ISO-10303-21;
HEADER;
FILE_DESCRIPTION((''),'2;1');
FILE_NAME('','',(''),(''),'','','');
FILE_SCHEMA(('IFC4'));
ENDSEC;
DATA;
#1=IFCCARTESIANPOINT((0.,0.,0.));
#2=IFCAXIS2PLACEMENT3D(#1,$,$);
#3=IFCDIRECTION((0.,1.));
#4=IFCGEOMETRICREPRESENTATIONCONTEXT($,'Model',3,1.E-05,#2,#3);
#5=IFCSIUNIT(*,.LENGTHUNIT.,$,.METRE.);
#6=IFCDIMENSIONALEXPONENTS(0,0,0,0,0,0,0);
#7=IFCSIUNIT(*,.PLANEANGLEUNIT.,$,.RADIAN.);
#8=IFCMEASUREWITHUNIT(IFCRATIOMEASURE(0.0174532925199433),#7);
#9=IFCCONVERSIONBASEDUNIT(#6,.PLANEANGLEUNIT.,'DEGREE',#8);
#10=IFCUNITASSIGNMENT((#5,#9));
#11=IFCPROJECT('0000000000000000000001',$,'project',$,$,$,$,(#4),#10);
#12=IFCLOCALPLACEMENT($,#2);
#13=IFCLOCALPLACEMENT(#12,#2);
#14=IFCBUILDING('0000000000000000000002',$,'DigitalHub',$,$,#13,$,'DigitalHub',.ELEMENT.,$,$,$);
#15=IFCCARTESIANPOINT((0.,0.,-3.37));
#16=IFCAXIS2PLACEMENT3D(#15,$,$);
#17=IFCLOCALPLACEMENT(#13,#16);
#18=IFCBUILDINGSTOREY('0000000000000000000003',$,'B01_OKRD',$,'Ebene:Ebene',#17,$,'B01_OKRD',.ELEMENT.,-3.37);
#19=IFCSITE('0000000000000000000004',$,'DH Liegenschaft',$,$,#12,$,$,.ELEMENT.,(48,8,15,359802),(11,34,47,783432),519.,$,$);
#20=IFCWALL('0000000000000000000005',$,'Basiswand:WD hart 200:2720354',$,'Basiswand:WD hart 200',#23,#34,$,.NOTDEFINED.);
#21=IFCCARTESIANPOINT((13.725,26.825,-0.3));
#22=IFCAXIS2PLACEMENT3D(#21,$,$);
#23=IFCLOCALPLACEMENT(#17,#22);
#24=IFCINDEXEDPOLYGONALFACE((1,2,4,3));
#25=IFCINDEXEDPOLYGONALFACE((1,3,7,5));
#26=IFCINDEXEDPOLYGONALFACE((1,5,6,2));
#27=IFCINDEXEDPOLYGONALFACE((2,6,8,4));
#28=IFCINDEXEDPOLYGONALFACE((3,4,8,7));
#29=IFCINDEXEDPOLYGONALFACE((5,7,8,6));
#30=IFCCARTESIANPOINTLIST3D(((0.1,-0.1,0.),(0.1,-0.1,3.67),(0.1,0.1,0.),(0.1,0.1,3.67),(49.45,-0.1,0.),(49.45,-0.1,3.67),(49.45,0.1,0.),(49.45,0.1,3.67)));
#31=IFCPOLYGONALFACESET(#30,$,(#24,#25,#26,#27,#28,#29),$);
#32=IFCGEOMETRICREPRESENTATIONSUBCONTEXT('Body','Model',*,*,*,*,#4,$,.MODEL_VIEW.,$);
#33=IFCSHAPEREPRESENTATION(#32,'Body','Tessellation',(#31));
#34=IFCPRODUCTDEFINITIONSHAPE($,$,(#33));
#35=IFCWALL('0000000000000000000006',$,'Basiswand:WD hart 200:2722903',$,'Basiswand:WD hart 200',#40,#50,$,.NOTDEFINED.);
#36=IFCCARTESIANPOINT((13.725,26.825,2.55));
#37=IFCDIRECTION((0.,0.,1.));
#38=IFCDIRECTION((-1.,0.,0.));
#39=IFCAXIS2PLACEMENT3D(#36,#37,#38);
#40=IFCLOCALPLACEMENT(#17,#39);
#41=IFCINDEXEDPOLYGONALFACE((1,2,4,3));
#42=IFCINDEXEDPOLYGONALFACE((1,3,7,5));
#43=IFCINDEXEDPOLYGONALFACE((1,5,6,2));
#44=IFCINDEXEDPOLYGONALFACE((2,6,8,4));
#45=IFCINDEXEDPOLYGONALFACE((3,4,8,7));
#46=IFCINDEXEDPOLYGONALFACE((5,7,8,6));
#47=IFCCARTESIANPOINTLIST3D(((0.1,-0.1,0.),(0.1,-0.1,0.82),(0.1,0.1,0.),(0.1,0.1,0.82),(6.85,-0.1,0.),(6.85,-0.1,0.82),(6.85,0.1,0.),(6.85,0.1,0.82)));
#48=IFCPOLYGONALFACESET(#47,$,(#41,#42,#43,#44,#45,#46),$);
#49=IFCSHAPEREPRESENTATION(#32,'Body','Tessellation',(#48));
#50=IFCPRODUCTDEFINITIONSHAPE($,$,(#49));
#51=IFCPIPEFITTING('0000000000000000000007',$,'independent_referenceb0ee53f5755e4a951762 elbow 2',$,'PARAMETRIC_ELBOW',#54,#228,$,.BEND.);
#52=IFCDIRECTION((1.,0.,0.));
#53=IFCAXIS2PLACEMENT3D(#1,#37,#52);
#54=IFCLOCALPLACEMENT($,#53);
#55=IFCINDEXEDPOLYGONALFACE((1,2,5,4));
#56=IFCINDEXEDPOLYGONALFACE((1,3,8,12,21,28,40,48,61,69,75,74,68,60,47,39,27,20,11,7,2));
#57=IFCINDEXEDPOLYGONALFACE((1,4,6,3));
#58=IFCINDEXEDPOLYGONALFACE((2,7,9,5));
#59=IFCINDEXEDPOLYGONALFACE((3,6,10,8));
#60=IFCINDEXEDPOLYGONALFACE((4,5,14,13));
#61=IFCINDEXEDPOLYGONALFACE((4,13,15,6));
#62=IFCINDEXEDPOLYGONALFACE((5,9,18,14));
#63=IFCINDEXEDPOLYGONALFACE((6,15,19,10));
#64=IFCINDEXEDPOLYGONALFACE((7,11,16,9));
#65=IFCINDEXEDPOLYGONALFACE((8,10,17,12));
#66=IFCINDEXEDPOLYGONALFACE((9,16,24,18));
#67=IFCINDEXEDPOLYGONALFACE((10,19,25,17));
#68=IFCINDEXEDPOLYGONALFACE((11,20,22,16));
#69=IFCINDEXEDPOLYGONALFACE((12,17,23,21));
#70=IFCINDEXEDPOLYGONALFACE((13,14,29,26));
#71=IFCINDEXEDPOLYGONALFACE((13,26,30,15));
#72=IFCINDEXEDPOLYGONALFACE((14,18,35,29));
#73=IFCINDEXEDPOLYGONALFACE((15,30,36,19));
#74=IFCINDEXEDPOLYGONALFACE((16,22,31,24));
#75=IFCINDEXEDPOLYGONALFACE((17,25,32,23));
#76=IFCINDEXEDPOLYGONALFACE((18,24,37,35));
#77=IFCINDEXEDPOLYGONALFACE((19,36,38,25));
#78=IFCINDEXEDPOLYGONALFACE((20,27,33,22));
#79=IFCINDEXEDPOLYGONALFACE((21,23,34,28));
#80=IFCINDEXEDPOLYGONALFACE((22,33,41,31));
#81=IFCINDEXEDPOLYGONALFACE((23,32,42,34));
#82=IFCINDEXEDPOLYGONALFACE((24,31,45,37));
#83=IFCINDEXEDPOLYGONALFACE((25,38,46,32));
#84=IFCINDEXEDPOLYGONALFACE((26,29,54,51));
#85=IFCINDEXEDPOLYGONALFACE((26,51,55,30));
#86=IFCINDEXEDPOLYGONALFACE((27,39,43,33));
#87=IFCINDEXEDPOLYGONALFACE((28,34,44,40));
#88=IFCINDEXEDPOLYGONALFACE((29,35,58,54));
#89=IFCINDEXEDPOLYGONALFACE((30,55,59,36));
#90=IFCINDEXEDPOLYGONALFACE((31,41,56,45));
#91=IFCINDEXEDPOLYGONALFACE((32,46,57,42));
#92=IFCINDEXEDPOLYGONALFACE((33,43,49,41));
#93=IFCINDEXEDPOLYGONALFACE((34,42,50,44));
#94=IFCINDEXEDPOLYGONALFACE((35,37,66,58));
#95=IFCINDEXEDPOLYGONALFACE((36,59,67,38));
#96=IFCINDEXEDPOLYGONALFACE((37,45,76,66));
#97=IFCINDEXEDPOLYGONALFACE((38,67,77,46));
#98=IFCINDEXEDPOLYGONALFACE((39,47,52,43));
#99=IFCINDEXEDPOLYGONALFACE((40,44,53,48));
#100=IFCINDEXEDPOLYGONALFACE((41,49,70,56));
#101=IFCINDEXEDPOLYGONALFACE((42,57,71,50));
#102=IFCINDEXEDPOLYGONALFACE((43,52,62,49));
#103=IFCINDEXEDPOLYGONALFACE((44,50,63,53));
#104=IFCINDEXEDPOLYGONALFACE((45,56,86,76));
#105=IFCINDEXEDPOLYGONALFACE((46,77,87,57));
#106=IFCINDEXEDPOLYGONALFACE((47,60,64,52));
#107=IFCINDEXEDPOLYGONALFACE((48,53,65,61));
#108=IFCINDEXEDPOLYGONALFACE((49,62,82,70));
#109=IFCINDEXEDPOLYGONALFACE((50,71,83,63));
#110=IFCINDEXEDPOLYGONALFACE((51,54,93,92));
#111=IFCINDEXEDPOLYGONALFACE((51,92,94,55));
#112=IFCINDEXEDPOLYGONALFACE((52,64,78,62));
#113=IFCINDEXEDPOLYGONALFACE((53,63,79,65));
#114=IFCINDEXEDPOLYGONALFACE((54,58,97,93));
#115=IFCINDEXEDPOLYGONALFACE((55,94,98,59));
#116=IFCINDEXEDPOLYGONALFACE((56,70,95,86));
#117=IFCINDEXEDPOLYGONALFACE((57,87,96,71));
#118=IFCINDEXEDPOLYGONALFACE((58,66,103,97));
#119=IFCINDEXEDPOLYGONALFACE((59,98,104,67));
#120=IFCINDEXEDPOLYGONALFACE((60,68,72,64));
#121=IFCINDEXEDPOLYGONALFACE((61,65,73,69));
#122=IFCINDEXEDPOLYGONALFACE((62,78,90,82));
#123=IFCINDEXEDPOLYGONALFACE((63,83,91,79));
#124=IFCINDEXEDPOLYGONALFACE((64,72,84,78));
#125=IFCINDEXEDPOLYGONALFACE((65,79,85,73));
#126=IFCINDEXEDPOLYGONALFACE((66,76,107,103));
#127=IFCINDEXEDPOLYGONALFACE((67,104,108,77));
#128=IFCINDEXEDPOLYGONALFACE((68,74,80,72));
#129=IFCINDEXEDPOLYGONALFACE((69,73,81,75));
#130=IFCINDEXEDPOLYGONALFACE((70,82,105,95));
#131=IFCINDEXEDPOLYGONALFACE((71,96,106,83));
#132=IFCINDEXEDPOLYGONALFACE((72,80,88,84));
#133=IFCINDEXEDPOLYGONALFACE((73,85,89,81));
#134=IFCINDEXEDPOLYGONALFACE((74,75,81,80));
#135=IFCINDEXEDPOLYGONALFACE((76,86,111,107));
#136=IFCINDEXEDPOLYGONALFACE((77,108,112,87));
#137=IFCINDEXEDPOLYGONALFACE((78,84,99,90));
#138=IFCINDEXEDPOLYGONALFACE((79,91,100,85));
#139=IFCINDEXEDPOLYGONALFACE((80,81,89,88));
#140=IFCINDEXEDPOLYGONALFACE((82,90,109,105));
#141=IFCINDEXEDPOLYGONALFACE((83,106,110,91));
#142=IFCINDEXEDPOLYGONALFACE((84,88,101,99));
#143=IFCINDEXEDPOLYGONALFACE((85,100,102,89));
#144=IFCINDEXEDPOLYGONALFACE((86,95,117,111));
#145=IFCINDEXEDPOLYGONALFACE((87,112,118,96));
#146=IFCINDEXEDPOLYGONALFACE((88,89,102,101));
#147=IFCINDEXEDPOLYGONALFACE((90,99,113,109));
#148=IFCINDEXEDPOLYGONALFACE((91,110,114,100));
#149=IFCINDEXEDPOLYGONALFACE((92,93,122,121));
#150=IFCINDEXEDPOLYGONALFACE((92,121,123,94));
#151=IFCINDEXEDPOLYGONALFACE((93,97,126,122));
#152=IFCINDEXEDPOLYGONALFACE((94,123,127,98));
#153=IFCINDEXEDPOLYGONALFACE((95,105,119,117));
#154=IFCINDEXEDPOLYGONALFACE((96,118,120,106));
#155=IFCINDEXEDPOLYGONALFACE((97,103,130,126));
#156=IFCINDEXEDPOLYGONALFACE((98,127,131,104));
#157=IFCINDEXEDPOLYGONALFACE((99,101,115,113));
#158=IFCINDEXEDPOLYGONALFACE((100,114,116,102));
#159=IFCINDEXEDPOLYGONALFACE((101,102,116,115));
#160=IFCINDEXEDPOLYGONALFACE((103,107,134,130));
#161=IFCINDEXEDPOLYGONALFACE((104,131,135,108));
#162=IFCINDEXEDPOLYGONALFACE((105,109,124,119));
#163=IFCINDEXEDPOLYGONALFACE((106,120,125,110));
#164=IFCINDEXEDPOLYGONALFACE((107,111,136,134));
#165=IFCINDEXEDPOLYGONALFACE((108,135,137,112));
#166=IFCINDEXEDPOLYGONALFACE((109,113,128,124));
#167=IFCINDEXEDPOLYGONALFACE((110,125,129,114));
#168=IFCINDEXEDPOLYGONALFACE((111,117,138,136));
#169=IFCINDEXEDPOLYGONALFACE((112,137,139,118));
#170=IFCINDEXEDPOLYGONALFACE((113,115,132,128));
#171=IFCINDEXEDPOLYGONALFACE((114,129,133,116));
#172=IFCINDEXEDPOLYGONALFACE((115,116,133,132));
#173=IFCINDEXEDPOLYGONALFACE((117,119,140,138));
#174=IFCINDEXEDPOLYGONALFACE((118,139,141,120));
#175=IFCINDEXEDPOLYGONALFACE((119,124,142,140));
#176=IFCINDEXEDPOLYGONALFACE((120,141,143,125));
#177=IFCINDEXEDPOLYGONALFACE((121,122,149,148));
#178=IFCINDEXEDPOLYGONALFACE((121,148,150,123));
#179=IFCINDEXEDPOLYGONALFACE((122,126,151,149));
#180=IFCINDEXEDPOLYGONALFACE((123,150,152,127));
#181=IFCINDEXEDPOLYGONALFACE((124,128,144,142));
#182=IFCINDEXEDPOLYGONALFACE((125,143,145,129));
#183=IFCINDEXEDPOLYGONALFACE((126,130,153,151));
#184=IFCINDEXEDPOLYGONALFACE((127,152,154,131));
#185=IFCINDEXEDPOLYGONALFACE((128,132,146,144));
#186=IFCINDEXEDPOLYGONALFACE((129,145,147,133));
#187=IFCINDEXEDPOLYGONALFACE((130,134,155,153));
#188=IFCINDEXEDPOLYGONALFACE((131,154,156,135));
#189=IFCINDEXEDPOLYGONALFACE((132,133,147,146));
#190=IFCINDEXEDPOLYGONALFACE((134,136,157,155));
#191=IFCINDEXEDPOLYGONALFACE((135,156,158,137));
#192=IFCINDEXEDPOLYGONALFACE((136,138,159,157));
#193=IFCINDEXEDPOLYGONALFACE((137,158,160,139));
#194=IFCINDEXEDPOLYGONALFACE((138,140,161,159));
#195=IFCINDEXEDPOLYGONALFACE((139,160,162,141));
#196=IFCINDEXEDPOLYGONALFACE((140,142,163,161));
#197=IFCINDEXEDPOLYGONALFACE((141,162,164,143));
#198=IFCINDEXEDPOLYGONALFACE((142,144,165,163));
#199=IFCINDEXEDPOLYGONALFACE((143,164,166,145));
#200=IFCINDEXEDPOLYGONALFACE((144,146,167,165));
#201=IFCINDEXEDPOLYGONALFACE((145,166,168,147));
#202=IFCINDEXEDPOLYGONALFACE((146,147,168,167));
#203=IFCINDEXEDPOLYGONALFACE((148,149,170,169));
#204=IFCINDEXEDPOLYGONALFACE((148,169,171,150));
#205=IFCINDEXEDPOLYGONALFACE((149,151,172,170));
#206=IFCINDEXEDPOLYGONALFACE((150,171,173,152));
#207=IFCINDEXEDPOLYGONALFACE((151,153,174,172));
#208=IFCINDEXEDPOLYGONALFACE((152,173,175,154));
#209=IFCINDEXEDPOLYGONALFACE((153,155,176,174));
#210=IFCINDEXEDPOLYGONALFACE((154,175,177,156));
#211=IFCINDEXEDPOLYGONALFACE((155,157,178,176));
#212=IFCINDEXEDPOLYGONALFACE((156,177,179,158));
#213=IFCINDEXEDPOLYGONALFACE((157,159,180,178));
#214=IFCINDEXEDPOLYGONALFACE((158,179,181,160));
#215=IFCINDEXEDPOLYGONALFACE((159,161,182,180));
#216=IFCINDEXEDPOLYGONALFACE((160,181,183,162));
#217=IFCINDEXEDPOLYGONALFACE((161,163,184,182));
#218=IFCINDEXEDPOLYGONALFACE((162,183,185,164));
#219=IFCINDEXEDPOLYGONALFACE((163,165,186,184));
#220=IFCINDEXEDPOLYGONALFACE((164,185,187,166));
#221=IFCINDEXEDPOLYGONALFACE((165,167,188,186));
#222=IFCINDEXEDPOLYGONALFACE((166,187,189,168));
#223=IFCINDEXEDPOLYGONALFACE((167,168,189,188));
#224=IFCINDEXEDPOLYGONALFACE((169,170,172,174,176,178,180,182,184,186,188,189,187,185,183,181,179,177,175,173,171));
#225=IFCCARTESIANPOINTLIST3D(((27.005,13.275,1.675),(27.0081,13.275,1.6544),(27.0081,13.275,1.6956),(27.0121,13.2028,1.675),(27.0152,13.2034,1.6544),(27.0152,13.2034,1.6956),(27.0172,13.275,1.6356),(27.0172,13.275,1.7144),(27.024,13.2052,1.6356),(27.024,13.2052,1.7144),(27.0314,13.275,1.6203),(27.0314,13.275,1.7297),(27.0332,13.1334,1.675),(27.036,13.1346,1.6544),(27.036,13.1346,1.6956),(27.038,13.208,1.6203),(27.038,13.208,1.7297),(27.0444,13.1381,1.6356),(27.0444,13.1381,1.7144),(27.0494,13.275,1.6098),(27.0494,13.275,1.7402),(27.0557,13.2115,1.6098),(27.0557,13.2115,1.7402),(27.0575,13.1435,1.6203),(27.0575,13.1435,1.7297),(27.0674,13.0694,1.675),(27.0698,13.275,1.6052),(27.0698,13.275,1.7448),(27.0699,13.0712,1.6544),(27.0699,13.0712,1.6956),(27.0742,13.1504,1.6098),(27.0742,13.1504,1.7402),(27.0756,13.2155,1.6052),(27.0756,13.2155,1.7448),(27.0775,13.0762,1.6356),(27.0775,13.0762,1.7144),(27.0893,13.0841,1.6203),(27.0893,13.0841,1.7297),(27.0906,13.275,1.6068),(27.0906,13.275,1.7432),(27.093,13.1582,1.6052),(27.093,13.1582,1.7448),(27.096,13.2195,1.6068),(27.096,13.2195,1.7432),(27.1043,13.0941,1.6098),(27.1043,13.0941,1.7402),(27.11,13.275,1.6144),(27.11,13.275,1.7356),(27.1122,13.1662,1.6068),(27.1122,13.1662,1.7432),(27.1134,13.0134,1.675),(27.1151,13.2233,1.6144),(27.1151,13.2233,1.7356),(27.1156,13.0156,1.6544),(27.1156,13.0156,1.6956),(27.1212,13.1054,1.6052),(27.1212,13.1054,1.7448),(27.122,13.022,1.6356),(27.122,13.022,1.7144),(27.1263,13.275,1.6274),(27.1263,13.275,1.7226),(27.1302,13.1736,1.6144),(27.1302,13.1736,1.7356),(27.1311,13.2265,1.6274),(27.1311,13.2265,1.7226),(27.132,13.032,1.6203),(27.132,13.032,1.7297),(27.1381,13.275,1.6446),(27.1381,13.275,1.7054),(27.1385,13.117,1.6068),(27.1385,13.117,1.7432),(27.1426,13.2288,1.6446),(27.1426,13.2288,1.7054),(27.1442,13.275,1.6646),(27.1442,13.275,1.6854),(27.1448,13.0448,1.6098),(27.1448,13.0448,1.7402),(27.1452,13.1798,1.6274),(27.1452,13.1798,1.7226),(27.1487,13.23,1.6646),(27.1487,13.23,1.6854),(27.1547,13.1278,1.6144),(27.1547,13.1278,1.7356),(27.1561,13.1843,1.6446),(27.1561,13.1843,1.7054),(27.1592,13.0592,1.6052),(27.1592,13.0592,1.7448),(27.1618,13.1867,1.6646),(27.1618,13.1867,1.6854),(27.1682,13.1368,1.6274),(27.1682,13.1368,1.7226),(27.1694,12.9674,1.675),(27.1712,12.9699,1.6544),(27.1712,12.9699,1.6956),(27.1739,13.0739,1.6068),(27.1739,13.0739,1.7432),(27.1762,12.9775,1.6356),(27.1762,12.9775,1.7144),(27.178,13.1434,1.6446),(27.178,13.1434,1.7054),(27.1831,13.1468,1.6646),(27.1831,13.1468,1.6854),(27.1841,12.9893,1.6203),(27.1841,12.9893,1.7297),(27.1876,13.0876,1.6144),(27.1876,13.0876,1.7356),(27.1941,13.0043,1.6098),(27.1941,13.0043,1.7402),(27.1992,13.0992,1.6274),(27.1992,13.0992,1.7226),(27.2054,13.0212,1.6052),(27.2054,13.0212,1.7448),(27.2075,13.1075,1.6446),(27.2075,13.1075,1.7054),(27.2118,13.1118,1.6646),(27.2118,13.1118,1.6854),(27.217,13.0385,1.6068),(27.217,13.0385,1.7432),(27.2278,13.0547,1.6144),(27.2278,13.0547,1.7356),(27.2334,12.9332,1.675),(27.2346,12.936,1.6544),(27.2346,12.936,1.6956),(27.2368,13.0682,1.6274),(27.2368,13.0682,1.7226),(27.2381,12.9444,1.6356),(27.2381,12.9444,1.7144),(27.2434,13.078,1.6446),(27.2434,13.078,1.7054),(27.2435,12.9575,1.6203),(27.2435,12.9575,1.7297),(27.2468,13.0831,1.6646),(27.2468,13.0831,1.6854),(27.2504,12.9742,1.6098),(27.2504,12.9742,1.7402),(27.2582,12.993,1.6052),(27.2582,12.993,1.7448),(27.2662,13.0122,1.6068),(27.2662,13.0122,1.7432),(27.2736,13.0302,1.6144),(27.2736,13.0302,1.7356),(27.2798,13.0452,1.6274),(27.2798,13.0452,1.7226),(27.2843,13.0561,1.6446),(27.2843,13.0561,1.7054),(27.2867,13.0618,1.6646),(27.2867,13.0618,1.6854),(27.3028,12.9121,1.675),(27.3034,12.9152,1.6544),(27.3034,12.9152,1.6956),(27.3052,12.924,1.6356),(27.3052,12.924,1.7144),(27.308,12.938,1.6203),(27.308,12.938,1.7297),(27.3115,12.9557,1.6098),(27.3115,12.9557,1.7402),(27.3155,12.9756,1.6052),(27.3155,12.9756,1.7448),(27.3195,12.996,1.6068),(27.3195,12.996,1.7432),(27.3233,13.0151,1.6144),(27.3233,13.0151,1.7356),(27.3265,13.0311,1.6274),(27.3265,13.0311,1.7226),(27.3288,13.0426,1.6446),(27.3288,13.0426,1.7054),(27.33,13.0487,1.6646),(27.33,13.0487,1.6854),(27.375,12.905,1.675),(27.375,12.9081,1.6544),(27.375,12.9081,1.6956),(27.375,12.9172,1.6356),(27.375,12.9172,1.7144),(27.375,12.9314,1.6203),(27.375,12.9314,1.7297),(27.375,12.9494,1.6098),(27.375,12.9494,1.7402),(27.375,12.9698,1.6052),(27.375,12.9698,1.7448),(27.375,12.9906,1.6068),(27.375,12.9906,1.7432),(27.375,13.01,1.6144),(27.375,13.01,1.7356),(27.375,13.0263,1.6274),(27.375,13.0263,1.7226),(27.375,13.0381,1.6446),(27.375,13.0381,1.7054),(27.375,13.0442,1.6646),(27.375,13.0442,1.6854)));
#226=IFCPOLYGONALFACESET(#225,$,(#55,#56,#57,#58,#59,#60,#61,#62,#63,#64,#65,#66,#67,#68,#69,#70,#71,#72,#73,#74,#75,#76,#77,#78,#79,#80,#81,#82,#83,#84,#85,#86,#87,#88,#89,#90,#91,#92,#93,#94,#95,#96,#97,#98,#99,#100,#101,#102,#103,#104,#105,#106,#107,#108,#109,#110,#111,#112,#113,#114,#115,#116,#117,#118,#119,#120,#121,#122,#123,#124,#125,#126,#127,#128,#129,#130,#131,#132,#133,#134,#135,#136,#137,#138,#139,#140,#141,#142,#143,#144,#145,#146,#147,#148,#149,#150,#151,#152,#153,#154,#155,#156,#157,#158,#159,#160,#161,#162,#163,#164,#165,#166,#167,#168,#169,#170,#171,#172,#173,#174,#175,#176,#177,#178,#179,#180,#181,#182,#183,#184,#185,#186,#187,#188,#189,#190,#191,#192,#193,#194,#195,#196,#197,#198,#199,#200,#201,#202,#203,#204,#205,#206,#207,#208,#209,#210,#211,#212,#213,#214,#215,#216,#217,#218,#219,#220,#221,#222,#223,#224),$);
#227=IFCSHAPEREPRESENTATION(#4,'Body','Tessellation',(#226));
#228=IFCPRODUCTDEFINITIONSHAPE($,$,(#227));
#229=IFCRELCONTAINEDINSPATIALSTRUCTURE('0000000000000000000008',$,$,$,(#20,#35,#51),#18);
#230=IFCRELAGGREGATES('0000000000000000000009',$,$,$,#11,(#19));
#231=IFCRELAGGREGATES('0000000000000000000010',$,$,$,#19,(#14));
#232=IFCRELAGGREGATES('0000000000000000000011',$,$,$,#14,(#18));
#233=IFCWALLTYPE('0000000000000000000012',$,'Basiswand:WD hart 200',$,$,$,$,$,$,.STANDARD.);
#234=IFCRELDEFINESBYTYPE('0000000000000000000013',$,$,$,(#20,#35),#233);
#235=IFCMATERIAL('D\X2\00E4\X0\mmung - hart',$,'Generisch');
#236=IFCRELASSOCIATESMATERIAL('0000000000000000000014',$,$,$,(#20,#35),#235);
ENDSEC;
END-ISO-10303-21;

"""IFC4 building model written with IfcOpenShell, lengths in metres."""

from ifc_helpers import new_model, entity, si_unit, converted_unit, direction, frame, origin, origin_with_axes, place, context, subcontext, project, spatial, indexed_curve, outline, extrude, material, type_object, element, save


model = new_model("IFC4")

# Units and contexts
model_context = context("Model", 3, precision=1e-05, world=origin(), true_north=direction((0.0, 1.0)))
body_context = subcontext(model_context, "Body", "Model", "MODEL_VIEW")
ifc_project = project(units=[si_unit("LENGTHUNIT", "METRE"), converted_unit("PLANEANGLEUNIT", "DEGREE", entity("IfcRatioMeasure", 0.0174532925199433), si_unit("PLANEANGLEUNIT", "RADIAN"), dimensions=[0, 0, 0, 0, 0, 0, 0])], contexts=[model_context])

# Site, building, storey
site_placement = place(None, frame((0.0, 0.0, 0.0)))
site = spatial("IfcSite", under=ifc_project, at=site_placement, Name="DH Liegenschaft", CompositionType="ELEMENT", RefLatitude=(48, 8, 15, 359802), RefLongitude=(11, 34, 47, 783432), RefElevation=519.0)
building_placement = place(site_placement, origin())
building = spatial("IfcBuilding", under=site, at=building_placement, Name="DigitalHub", LongName="DigitalHub", CompositionType="ELEMENT")
storey_placement = place(building_placement, frame((0.0, 0.0, -3.37)))
storey = spatial("IfcBuildingStorey", under=building, at=storey_placement, Name="B01_OKRD", ObjectType="Ebene:Ebene", LongName="B01_OKRD", CompositionType="ELEMENT", Elevation=-3.37)

# Shared definitions
ifc_material_1 = material(Name="Dämmung - hart", Category="Generisch")

# Walls
wall_type_1 = type_object("IfcWallType", Name="Basiswand:WD hart 200", PredefinedType="STANDARD")
wall_1_placement = place(storey_placement, frame((13.725, 26.825, -0.3)))
element("IfcWall", 1, at=wall_1_placement, inside=storey, type_object=wall_type_1, material=ifc_material_1, Name="Basiswand:WD hart 200:2720354", ObjectType="Basiswand:WD hart 200", PredefinedType="NOTDEFINED", context=body_context, shape_type="SweptSolid", body=[
    extrude(outline(indexed_curve([(49.45, -0.1), (49.45, 0.1), (0.1, 0.1), (0.1, -0.1), (49.45, -0.1)], self_intersect=False)), origin(), (0.0, 0.0, 1.0), 3.67),
])
wall_2_placement = place(storey_placement, frame((13.725, 26.825, 2.55), z_axis=(0.0, 0.0, 1.0), x_axis=(-1.0, 0.0, 0.0)))
element("IfcWall", 2, at=wall_2_placement, inside=storey, type_object=wall_type_1, material=ifc_material_1, Name="Basiswand:WD hart 200:2722903", ObjectType="Basiswand:WD hart 200", PredefinedType="NOTDEFINED", context=body_context, shape_type="SweptSolid", body=[
    extrude(outline(indexed_curve([(6.85, -0.1), (6.85, 0.1), (0.1, 0.1), (0.1, -0.1), (6.85, -0.1)], self_intersect=False)), origin(), (0.0, 0.0, 1.0), 0.82),
])

# Pipe fitting
pipe_fitting_1_placement = place(None, origin_with_axes())
element("IfcPipeFitting", 3, at=pipe_fitting_1_placement, inside=storey, Name="independent_referenceb0ee53f5755e4a951762 elbow 2", ObjectType="PARAMETRIC_ELBOW", PredefinedType="BEND", context=model_context, shape_type="SweptSolid", body=[
    entity("IfcRevolvedAreaSolid", entity("IfcCircleProfileDef", "AREA", None, entity("IfcAxis2Placement2D", entity("IfcCartesianPoint", [0.3, 0.0])), 0.07), entity("IfcAxis2Placement3D", entity("IfcCartesianPoint", [27.375, 13.275, 1.675]), entity("IfcDirection", [0.0, -1.0, 0.0]), entity("IfcDirection", [-1.0, 0.0, 0.0])), entity("IfcAxis1Placement", entity("IfcCartesianPoint", [0.0, 0.0, 0.0]), entity("IfcDirection", [0.0, -1.0, 0.0])), 90.0),
])

save(model, "model.ifc")
